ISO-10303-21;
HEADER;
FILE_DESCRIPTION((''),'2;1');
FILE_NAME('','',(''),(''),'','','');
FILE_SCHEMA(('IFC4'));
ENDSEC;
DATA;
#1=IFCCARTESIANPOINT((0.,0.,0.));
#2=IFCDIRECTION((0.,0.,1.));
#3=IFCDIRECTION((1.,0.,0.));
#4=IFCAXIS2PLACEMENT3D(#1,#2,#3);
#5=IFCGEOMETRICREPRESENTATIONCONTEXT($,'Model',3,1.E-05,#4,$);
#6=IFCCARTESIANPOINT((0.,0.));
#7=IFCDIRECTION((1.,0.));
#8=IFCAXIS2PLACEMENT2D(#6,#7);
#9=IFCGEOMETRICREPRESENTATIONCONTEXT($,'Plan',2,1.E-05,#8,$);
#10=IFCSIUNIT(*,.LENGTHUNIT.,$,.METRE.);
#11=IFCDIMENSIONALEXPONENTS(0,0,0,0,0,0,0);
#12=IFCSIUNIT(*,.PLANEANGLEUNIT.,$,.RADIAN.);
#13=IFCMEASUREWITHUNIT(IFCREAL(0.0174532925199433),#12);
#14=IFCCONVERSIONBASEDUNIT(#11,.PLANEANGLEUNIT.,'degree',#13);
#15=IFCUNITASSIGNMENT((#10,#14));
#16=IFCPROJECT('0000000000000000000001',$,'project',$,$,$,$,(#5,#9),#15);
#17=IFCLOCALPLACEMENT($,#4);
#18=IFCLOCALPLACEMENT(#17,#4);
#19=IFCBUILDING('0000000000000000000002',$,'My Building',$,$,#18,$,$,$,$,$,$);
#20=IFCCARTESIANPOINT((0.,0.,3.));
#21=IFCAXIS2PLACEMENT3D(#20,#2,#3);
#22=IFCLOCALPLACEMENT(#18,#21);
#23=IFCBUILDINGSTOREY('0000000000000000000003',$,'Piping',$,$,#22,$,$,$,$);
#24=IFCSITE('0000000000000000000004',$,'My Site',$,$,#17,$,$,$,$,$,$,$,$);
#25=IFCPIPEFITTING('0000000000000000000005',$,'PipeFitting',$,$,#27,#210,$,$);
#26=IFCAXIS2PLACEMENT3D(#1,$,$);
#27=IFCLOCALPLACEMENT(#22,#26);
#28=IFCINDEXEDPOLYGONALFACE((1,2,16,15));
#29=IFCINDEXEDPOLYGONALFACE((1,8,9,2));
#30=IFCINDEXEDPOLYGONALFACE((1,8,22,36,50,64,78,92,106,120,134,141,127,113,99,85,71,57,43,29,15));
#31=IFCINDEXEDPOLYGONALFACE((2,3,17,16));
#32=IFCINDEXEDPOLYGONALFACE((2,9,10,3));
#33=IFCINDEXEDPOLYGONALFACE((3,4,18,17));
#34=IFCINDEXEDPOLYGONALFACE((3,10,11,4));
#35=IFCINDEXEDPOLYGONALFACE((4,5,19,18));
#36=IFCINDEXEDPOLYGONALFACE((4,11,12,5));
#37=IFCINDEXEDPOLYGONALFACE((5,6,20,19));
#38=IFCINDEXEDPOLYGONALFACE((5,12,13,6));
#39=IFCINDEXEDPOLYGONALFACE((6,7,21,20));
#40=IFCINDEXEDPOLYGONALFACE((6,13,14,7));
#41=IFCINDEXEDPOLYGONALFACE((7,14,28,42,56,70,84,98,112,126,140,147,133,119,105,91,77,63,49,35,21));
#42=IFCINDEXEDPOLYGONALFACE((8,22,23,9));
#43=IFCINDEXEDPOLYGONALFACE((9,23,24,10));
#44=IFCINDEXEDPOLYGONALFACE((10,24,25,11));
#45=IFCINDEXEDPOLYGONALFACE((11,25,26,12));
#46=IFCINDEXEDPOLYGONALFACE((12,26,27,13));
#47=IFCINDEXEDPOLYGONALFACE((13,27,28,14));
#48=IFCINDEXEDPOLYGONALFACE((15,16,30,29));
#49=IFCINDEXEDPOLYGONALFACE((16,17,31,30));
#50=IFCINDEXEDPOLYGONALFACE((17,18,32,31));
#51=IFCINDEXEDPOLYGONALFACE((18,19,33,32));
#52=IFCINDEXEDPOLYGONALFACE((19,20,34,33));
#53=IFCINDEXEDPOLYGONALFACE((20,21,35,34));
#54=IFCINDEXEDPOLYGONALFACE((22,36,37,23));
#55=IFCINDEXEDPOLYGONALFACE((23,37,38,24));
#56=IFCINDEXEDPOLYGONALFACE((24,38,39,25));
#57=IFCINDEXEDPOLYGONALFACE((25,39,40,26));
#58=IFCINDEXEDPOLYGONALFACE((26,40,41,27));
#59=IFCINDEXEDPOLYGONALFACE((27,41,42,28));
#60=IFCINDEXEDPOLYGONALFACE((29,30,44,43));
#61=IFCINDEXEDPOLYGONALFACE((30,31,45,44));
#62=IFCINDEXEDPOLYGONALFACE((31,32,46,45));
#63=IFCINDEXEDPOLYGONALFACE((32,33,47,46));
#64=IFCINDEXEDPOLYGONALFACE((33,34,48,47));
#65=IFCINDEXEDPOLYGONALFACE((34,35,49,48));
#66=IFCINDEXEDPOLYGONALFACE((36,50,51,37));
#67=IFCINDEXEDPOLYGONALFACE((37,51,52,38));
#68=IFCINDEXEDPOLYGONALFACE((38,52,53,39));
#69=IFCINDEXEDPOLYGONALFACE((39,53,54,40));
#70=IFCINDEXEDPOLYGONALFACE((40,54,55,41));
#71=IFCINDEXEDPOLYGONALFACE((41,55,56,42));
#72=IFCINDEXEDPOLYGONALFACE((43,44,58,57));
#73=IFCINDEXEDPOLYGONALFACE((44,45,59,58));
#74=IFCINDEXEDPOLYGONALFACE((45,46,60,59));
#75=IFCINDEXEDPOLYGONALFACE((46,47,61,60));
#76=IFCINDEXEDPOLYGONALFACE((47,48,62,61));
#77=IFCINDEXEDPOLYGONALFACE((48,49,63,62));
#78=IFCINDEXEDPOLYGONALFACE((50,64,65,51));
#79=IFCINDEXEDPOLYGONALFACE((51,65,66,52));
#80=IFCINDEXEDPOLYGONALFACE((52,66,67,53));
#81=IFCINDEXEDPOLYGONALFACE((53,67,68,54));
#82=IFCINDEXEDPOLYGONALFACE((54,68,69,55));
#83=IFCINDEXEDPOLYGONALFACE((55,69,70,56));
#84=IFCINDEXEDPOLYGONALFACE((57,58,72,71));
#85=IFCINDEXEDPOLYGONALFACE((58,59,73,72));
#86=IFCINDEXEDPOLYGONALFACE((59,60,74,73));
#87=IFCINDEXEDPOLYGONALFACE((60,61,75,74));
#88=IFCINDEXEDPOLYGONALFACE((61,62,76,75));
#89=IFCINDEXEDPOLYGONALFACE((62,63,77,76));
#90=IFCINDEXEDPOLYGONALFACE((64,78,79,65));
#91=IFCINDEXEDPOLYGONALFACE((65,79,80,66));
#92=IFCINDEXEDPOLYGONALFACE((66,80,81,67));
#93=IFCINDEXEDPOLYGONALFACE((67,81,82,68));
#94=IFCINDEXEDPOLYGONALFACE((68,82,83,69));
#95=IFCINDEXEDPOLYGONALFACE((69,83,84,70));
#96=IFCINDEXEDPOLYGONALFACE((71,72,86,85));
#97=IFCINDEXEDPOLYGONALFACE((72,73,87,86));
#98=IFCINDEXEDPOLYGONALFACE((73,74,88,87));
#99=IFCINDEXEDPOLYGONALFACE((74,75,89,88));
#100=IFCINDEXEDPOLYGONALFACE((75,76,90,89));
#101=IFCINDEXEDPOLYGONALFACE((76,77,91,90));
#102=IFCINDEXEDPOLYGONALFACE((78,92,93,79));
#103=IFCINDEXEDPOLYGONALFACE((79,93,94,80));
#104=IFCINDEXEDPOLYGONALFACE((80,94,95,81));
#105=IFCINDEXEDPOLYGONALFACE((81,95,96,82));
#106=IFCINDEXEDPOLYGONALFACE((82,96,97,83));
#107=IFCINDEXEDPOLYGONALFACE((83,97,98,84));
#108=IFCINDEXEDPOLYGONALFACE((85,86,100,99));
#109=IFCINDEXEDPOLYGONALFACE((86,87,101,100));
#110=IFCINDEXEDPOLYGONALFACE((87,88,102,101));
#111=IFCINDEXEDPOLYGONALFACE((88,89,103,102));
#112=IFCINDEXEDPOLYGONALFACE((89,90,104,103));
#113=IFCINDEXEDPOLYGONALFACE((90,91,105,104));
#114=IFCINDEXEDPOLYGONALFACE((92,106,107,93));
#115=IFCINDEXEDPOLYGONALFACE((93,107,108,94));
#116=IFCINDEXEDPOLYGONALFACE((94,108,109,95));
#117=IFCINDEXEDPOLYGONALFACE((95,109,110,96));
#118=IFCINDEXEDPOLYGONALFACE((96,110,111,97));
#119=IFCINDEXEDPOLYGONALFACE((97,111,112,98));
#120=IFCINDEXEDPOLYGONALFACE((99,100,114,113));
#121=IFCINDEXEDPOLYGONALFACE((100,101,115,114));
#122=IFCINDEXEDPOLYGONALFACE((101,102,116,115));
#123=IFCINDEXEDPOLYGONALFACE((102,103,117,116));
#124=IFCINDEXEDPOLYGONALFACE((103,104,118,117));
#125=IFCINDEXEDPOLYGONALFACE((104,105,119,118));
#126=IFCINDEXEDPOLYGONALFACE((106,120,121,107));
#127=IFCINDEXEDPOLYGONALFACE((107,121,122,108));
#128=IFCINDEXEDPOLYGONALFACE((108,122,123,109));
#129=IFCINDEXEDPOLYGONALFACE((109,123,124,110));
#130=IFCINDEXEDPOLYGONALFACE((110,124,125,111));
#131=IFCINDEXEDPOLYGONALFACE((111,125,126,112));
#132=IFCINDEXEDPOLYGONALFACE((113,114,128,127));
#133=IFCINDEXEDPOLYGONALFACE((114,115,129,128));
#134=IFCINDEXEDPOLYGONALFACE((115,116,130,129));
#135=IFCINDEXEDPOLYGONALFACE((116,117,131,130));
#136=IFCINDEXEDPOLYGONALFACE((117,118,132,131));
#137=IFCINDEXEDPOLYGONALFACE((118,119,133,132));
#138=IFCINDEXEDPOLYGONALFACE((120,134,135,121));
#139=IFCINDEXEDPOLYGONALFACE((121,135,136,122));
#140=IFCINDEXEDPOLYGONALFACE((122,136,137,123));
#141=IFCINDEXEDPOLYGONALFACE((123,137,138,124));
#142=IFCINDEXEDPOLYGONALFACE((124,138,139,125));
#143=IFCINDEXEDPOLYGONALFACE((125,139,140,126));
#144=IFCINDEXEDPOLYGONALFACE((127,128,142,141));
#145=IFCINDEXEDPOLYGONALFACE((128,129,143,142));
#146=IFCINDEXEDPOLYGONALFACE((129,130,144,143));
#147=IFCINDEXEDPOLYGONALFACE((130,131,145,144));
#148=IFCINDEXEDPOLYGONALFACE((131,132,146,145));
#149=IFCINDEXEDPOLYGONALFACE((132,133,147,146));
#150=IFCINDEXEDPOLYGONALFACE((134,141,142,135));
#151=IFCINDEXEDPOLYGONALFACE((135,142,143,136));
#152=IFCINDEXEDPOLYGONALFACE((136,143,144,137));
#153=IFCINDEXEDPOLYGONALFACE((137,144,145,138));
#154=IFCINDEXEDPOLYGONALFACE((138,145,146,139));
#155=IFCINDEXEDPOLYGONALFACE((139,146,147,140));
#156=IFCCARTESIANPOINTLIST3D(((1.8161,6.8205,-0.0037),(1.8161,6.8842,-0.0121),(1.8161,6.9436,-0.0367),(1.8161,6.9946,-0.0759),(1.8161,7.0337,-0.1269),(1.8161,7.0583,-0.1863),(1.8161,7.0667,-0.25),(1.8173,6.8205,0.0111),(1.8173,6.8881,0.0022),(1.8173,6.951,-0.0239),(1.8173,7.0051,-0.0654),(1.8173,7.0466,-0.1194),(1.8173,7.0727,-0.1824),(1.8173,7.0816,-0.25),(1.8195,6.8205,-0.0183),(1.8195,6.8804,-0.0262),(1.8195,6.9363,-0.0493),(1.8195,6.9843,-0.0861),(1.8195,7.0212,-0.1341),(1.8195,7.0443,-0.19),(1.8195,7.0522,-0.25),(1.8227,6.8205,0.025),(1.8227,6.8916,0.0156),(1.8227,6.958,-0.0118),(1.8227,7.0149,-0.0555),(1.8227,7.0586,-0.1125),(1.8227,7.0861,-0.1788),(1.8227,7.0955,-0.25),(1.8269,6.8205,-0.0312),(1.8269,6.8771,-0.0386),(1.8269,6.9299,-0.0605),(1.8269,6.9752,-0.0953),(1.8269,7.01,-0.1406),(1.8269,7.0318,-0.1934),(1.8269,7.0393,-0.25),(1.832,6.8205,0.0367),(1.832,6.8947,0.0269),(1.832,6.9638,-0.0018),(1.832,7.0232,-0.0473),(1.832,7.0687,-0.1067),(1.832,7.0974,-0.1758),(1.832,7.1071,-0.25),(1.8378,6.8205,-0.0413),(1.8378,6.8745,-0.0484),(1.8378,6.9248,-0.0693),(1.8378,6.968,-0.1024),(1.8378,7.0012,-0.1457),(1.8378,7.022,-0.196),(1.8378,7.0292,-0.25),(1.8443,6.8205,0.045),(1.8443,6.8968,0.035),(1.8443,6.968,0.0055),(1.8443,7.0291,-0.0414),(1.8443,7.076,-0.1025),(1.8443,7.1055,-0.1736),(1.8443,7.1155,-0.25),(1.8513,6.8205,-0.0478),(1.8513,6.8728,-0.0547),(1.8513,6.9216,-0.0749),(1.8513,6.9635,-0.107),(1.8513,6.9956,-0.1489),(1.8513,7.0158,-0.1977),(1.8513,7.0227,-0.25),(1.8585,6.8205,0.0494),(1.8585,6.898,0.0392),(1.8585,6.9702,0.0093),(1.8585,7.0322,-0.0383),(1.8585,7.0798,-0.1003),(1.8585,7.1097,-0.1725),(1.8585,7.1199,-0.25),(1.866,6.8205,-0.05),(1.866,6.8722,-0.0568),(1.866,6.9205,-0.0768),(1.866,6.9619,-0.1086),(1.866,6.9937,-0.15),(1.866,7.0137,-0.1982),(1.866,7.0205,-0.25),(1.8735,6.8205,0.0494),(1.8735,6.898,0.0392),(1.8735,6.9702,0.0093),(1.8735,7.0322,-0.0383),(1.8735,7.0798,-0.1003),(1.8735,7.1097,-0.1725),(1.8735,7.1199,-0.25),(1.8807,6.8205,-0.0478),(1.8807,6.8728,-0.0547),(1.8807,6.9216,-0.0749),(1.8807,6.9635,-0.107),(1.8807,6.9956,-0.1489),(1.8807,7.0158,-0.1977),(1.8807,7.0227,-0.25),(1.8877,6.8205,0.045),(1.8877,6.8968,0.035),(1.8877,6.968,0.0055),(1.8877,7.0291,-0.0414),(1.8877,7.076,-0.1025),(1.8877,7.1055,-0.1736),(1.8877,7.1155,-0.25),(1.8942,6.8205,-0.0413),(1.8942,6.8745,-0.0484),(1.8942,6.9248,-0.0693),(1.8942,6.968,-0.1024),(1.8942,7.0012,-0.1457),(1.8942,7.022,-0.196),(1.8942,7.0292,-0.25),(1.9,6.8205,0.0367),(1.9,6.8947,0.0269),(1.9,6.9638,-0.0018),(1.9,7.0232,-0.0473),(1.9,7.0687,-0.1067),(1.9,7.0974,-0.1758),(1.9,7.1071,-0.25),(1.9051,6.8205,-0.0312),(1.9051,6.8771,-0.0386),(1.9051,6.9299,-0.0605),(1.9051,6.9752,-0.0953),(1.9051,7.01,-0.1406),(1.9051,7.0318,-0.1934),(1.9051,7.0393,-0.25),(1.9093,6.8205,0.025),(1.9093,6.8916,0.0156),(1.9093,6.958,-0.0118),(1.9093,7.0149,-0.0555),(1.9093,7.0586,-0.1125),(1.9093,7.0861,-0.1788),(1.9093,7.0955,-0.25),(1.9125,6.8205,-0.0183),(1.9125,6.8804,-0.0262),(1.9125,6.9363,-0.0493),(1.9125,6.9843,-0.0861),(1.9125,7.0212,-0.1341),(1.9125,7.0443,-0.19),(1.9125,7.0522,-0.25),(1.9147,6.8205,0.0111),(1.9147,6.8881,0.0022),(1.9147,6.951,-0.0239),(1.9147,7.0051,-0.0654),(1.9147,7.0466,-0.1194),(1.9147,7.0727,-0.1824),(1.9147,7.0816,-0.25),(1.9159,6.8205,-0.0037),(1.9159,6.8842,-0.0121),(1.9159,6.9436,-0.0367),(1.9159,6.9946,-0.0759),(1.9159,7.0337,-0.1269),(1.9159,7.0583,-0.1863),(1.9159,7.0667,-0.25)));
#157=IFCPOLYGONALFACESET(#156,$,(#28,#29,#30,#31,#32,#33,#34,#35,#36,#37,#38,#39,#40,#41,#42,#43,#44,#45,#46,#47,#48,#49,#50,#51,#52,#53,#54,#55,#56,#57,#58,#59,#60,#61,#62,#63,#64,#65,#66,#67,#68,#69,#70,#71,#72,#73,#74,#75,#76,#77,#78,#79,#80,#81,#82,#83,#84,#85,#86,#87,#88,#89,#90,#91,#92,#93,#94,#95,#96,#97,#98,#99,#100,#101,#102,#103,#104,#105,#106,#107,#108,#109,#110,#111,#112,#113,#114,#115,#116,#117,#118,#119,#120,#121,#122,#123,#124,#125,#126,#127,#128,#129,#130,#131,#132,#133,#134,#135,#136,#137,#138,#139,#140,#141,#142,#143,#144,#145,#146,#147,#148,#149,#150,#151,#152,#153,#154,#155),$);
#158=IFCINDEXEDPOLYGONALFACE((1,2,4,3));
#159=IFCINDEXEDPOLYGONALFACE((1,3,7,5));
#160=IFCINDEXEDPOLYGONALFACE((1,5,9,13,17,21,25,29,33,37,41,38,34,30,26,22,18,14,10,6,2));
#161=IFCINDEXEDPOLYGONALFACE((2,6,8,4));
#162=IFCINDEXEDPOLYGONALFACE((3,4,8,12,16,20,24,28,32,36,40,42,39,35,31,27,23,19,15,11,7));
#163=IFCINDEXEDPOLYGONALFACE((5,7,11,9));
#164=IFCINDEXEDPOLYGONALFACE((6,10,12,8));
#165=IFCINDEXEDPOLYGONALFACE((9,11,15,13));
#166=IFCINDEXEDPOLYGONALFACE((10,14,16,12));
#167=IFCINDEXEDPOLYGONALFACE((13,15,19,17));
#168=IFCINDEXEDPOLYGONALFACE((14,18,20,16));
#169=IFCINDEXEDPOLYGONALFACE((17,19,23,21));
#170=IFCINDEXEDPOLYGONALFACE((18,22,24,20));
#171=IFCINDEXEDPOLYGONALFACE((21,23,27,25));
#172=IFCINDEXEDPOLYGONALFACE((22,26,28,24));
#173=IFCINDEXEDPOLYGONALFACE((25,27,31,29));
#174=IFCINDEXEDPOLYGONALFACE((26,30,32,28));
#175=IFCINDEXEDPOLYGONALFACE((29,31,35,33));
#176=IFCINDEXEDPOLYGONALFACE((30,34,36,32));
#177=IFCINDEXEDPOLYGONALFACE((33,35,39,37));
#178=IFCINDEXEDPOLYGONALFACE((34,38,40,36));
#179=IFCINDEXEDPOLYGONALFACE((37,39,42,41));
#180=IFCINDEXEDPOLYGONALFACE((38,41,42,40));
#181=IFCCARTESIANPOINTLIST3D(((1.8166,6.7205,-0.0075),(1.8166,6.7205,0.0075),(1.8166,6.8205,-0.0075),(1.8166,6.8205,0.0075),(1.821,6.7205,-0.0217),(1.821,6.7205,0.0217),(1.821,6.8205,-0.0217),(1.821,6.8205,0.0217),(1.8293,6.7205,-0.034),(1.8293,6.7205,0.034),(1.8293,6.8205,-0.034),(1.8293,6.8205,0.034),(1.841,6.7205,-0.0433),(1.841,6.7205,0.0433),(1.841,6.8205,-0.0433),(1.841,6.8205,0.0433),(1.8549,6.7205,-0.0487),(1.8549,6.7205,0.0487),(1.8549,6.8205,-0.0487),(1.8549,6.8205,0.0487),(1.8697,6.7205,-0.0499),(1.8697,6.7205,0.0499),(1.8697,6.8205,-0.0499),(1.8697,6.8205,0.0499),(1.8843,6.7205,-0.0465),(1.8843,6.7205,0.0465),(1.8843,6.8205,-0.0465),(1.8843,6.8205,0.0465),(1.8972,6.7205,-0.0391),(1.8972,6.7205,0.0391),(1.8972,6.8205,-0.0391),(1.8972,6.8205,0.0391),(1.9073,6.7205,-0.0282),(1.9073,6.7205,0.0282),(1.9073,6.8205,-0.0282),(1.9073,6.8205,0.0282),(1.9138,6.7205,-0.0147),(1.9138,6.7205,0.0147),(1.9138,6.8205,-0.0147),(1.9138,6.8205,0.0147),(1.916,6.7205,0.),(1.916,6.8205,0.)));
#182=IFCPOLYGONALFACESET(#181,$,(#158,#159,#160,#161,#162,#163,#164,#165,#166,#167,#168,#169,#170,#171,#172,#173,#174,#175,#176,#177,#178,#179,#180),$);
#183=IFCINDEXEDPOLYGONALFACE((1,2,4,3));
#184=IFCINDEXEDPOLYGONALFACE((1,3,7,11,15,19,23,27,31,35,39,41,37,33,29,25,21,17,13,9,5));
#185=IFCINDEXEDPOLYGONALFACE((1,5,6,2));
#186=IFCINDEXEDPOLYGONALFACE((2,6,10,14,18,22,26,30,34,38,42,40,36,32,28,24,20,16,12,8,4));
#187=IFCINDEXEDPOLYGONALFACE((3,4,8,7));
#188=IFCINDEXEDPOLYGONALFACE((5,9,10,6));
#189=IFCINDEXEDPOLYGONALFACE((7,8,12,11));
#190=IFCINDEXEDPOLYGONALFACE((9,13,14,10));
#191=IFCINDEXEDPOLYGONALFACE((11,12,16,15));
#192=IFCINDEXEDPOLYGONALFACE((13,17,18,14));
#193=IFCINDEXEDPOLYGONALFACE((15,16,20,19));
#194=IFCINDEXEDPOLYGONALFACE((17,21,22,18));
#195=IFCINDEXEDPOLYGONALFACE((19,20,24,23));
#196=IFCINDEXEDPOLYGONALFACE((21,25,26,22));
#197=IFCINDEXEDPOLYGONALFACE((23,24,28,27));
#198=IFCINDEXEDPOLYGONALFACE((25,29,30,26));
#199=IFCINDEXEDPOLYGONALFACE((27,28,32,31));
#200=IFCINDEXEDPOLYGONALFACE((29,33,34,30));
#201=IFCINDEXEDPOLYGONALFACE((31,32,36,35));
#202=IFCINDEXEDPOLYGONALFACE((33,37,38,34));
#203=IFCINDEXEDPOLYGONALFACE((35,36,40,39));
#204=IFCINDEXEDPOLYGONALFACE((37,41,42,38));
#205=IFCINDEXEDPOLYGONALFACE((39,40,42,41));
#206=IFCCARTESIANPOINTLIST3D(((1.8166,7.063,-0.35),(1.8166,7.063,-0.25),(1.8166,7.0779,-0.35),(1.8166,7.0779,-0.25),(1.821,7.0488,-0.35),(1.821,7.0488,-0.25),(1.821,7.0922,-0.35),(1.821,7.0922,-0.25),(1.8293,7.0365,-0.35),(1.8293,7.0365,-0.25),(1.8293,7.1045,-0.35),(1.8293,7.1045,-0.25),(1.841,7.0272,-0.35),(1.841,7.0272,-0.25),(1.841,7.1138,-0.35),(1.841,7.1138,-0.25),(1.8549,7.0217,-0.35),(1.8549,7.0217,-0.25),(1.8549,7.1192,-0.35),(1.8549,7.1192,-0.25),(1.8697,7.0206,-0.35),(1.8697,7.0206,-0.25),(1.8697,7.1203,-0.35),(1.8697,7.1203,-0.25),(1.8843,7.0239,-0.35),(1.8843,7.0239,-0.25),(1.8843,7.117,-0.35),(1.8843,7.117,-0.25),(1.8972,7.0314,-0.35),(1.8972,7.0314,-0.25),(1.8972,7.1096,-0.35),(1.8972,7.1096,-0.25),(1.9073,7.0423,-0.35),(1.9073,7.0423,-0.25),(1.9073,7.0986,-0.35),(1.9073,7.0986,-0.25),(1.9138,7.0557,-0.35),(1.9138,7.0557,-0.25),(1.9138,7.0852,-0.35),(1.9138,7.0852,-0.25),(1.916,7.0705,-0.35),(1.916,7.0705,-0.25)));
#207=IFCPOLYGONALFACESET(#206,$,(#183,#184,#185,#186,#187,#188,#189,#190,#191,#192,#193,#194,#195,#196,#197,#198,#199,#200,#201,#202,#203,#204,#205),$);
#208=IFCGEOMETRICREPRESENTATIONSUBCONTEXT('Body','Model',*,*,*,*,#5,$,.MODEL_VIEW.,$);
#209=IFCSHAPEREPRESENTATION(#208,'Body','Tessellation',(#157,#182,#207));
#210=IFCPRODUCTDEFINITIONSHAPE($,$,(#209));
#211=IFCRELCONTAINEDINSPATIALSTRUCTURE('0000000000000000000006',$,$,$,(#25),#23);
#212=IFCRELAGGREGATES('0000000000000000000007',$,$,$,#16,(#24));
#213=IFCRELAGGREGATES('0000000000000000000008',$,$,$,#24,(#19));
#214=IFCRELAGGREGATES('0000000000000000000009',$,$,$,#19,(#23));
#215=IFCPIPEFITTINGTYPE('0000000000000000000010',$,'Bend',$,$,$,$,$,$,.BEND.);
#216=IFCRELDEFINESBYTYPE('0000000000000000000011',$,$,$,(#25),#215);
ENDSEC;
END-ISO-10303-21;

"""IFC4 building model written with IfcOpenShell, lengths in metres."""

from ifc_helpers import new_model, entity, si_unit, converted_unit, frame, origin_with_axes, origin_2d_with_axis, place, context, subcontext, project, spatial, circle, extrude, source, transform, mapped, type_object, type_shapes, element, save


model = new_model("IFC4")

# Units and contexts
model_context = context("Model", 3, precision=1e-05, world=origin_with_axes())
plan_context = context("Plan", 2, precision=1e-05, world=origin_2d_with_axis())
body_context = subcontext(model_context, "Body", "Model", "MODEL_VIEW")
ifc_project = project(units=[si_unit("LENGTHUNIT", "METRE"), converted_unit("PLANEANGLEUNIT", "degree", entity("IfcReal", 0.0174532925199433), si_unit("PLANEANGLEUNIT", "RADIAN"), dimensions=[0, 0, 0, 0, 0, 0, 0])], contexts=[model_context, plan_context])

# Site, building, storey
site_placement = place(None, origin_with_axes())
site = spatial("IfcSite", under=ifc_project, at=site_placement, Name="My Site")
building_placement = place(site_placement, origin_with_axes())
building = spatial("IfcBuilding", under=site, at=building_placement, Name="My Building")
storey_placement = place(building_placement, frame((0.0, 0.0, 3.0), z_axis=(0.0, 0.0, 1.0), x_axis=(1.0, 0.0, 0.0)))
storey = spatial("IfcBuildingStorey", under=building, at=storey_placement, Name="Piping")

# Pipe fitting
pipe_fitting_type = type_object("IfcPipeFittingType", Name="Bend", PredefinedType="BEND")
shared_shape = source(origin_with_axes(), body_context, "Body", "SolidModel", [
    entity("IfcSweptDiskSolid", entity("IfcIndexedPolyCurve", entity("IfcCartesianPointList3D", [[0.0, 0.0, -0.1], [0.0, -0.0732, -0.2768], [0.0, -0.25, -0.35]]), [entity("IfcArcIndex", [1, 2, 3])]), 0.05),
    extrude(circle(Radius=0.05), origin_with_axes(), (0.0, 0.0, -1.0), 0.1),
    extrude(circle(Radius=0.05), frame((0.0, -0.25, -0.35), z_axis=(0.0, -1.0, 0.0), x_axis=(1.0, 0.0, 0.0)), (0.0, 0.0, 1.0), 0.1),
])
type_shapes(pipe_fitting_type, [shared_shape])
for number, where, z_axis, x_axis, name in (
    (1, (1.866, 6.7205, 0.0), (0.0, -1.0, 0.0), (1.0, 0.0, 0.0), "PipeFitting"),
):
    element("IfcPipeFitting", number, at=place(storey_placement, frame(where, z_axis=z_axis, x_axis=x_axis)), inside=storey, type_object=pipe_fitting_type, Name=name, context=body_context, shape_type="MappedRepresentation", body=[
        mapped(shared_shape, transform((0.0, 0.0, 0.0), x_axis=(1.0, 0.0, 0.0), y_axis=(0.0, 1.0, 0.0), z_axis=(0.0, 0.0, 1.0), scale=1.0)),
    ])

save(model, "model.ifc")
